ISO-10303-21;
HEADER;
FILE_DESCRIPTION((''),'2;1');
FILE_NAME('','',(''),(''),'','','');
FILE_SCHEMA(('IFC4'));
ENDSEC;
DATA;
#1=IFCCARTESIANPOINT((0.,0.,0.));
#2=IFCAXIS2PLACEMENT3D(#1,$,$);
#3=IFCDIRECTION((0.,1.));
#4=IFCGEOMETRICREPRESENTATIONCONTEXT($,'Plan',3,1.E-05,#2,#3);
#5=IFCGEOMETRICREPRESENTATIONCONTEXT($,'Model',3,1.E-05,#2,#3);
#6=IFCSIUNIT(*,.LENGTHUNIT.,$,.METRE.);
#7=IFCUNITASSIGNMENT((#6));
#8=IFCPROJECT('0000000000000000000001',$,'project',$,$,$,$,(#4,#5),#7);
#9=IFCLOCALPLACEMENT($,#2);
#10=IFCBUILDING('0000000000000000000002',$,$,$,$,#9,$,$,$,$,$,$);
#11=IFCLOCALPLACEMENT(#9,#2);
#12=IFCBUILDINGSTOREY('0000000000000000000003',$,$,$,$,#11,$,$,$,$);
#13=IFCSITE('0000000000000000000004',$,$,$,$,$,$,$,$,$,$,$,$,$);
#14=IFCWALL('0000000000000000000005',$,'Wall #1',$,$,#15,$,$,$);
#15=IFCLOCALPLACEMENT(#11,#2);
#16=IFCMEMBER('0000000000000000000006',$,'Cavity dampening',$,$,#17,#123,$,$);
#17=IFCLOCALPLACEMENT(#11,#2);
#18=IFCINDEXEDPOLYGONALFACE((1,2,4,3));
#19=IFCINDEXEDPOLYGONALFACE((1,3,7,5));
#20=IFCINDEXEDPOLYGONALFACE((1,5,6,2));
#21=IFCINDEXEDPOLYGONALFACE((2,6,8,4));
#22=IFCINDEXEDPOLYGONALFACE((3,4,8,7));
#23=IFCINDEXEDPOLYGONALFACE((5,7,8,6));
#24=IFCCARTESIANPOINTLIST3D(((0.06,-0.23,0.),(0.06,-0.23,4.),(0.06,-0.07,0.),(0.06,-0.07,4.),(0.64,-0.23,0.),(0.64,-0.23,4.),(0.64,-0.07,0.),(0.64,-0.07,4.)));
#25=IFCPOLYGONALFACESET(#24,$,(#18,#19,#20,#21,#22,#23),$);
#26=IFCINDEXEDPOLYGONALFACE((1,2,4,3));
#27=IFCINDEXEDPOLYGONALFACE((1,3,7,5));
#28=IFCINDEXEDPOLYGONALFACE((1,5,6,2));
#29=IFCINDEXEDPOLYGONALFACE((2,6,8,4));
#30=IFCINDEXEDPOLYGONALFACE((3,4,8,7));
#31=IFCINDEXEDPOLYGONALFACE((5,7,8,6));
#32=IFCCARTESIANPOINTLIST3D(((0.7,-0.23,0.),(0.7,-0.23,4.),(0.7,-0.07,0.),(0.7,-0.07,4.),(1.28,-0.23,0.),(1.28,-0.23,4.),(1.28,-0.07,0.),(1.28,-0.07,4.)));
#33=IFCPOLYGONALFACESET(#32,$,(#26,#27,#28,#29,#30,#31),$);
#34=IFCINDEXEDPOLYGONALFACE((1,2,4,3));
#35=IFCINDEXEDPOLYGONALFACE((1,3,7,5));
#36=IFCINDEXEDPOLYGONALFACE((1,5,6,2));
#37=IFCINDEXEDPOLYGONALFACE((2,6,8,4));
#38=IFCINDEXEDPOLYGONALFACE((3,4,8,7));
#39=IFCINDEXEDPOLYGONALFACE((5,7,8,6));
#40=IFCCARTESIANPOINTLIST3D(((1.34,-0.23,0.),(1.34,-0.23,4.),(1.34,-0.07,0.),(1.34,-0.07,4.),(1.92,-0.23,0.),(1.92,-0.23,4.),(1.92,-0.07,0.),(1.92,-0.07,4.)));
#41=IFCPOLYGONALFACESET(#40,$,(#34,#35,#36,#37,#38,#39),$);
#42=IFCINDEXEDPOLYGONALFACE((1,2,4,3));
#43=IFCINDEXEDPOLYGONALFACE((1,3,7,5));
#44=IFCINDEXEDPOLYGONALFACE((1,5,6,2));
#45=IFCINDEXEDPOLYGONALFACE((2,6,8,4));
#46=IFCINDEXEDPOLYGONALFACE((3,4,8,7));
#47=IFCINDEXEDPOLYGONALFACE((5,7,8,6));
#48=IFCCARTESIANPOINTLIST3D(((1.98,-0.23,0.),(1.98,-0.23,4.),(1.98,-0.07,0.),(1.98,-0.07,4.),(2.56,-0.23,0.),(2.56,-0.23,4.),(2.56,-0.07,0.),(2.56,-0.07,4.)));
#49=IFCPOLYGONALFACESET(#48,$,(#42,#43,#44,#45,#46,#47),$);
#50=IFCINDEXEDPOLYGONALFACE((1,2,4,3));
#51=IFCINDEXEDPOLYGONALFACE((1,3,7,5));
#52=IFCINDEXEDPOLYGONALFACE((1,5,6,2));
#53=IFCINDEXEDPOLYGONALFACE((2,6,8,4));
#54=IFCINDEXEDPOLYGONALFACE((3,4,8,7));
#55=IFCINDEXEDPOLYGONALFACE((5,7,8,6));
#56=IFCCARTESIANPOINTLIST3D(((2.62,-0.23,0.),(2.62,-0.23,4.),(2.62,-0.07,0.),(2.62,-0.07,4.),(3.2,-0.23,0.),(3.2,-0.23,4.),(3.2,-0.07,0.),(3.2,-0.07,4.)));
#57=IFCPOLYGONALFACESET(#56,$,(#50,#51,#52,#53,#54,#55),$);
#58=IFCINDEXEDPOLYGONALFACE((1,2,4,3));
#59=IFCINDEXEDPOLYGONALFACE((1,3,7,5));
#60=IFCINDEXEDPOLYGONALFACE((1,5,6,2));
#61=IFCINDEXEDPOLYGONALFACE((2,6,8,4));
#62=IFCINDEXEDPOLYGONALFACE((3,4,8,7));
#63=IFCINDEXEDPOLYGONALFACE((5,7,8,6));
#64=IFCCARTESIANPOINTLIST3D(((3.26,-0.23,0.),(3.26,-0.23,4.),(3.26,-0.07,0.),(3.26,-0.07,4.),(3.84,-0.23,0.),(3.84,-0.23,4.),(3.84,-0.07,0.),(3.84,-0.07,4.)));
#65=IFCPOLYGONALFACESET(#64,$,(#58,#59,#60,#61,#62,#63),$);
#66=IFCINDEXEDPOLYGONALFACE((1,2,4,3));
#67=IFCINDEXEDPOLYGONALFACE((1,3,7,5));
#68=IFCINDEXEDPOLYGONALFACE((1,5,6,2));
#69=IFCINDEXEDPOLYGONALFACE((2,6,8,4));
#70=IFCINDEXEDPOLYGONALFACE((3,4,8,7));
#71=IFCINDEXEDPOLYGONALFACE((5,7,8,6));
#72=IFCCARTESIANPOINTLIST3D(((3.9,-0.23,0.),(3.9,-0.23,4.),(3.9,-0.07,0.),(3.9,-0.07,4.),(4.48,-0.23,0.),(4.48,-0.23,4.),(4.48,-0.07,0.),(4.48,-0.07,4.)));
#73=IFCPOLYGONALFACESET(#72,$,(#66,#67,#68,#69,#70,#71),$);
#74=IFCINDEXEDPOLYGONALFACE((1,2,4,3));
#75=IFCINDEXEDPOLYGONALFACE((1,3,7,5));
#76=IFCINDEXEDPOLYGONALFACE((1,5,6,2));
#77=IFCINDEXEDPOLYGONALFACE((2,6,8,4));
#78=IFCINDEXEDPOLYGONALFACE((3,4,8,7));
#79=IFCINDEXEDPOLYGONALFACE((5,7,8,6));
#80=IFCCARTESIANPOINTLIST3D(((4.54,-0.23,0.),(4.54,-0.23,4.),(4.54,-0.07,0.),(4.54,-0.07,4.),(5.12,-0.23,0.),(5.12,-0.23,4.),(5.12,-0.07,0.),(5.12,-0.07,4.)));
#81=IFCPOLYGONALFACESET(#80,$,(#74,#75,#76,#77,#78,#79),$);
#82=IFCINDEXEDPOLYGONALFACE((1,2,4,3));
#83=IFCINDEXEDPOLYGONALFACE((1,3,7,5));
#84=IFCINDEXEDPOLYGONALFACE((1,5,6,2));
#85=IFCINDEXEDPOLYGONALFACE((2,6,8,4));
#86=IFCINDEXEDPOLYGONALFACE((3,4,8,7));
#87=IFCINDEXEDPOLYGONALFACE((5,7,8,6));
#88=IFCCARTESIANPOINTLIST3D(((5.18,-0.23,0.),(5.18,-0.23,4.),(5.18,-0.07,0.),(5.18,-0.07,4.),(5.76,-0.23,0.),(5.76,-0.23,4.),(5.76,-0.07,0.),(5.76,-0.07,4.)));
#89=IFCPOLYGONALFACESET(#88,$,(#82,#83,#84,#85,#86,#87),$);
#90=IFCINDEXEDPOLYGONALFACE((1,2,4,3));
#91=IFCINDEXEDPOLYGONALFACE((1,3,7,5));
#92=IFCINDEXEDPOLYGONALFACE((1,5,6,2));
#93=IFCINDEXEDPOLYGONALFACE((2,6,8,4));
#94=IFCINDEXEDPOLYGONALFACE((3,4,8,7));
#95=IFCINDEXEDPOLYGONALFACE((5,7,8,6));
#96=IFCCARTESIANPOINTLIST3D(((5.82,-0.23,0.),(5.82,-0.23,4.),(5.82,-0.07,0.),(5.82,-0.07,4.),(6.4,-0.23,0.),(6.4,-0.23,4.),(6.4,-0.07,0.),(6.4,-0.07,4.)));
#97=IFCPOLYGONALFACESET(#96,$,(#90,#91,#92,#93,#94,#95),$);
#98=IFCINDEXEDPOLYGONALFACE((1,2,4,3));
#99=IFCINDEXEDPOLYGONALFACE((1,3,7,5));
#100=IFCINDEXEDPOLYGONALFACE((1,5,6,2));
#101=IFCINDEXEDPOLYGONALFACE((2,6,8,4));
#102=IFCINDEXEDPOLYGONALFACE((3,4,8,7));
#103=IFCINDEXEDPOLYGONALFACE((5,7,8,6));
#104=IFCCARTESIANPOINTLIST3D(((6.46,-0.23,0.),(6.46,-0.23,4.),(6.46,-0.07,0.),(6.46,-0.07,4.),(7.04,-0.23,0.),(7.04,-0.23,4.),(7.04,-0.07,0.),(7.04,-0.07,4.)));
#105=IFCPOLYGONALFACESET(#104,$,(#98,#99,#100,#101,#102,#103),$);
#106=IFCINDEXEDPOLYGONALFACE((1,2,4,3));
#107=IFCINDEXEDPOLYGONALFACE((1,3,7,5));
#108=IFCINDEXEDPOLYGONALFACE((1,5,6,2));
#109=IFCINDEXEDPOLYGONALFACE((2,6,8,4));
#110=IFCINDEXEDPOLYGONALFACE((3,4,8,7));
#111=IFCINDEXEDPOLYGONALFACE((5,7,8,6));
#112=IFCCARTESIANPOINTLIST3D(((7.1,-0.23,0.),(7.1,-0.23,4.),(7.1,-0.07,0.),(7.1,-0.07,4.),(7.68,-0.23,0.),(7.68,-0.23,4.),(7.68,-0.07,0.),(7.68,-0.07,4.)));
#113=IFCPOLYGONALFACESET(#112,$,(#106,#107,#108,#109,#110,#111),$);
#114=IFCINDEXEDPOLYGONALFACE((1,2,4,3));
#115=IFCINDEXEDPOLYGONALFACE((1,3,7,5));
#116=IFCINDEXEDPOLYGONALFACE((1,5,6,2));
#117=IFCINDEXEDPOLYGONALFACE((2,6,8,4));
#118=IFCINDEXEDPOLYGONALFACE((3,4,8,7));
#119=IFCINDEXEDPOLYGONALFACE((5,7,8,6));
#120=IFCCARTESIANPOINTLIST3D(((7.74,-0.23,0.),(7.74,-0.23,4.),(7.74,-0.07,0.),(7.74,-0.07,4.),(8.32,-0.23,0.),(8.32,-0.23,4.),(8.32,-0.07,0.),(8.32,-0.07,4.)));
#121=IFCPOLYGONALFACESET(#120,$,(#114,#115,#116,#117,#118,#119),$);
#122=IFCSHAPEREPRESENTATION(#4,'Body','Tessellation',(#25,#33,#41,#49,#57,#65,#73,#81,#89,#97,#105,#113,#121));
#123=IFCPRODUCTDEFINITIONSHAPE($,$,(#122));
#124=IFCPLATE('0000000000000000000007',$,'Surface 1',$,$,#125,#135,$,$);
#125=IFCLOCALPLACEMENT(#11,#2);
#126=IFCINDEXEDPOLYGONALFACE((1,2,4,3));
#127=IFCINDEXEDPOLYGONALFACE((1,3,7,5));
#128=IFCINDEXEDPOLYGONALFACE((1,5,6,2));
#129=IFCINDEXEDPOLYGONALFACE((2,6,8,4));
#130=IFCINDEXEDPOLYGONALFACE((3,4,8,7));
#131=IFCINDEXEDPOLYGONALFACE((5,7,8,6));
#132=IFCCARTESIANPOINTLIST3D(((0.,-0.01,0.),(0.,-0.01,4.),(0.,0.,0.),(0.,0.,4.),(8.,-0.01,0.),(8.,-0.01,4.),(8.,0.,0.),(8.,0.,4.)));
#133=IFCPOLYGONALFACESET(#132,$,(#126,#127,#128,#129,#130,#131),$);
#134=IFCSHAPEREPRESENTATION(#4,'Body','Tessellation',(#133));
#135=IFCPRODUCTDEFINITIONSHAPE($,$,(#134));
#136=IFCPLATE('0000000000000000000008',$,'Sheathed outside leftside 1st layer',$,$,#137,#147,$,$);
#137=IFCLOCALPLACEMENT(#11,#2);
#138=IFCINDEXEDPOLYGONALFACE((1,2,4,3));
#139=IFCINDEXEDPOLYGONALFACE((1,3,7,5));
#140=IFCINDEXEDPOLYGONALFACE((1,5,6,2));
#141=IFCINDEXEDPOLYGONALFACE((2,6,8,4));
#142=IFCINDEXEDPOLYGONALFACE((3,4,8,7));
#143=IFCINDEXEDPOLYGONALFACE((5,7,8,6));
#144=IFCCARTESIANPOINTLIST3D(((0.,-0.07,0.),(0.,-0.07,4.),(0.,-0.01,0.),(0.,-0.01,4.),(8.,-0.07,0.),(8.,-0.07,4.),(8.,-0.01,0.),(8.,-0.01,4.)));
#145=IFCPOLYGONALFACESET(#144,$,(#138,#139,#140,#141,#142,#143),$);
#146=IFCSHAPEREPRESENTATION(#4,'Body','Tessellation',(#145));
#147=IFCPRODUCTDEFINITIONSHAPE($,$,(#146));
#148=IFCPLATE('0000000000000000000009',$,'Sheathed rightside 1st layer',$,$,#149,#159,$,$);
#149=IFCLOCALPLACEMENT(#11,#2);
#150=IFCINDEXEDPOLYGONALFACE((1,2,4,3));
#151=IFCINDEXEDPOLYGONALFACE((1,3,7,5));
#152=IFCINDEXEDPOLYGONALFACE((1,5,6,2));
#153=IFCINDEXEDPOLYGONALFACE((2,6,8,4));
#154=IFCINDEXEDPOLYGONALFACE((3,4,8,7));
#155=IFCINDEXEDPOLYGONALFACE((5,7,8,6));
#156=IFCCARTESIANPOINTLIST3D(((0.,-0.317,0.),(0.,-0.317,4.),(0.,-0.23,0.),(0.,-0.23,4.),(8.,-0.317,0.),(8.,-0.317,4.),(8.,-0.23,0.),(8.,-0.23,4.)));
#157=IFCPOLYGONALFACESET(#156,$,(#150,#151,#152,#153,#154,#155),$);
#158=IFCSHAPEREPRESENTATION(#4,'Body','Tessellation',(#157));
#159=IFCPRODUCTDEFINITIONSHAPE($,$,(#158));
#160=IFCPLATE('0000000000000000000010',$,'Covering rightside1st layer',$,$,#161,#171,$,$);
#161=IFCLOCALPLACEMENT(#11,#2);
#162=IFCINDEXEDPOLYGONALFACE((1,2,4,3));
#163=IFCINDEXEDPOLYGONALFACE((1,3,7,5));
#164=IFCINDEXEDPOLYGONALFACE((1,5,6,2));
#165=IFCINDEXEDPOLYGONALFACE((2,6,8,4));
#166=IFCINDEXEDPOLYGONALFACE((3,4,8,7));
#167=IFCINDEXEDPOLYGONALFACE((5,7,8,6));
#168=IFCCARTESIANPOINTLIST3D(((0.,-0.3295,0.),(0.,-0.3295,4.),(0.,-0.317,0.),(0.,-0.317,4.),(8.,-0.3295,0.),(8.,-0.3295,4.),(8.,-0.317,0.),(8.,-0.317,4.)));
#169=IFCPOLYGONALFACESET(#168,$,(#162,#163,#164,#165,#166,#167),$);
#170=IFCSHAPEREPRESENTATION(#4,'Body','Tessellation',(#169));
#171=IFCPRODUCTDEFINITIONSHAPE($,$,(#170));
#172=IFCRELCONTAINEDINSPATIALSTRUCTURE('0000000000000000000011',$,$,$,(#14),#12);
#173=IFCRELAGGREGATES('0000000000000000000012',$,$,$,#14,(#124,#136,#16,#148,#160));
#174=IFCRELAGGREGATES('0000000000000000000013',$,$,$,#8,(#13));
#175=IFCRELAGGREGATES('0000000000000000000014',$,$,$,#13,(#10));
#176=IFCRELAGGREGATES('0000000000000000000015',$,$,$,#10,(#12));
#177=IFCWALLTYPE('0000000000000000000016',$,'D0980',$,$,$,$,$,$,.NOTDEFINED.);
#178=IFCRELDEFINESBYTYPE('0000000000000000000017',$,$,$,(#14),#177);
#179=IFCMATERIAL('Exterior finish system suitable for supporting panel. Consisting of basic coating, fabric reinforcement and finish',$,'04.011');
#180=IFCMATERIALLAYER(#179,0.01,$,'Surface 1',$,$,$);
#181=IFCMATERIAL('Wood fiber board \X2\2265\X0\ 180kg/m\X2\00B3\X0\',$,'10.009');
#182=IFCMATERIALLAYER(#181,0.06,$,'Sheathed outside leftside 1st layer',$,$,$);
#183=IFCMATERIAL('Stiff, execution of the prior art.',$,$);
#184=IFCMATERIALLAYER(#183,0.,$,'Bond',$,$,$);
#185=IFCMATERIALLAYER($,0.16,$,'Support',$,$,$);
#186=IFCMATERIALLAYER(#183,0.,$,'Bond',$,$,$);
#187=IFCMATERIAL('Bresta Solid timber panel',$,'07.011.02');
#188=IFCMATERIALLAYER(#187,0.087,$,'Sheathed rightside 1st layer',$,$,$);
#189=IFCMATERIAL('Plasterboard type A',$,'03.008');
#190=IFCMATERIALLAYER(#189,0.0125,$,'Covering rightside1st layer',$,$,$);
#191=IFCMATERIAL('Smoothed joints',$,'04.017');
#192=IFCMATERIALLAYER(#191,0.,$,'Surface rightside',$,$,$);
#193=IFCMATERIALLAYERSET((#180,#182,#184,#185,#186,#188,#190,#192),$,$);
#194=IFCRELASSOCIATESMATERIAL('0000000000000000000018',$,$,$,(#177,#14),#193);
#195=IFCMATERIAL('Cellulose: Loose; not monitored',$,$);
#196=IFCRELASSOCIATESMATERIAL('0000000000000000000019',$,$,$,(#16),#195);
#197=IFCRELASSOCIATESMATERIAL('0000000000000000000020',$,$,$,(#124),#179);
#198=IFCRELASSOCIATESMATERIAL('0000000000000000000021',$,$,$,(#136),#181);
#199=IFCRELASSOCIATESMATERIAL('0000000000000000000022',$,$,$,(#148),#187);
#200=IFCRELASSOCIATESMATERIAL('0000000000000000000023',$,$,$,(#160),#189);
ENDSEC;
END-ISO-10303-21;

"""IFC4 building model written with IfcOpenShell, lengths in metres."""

from ifc_helpers import new_model, si_unit, direction, frame, frame_2d, origin, origin_with_axes, place, context, project, spatial, rectangle, extrude, material, layer, layer_set, type_object, element, aggregate, save


model = new_model("IFC4")

# Units and contexts
plan_context = context("Plan", 3, precision=1e-05, world=origin(), true_north=direction((0.0, 1.0)))
model_context = context("Model", 3, precision=1e-05, world=origin(), true_north=direction((0.0, 1.0)))
ifc_project = project(units=[si_unit("LENGTHUNIT", "METRE")], contexts=[plan_context, model_context])

# Site, building, storey
site = spatial("IfcSite", under=ifc_project)
building_placement = place(None, origin())
building = spatial("IfcBuilding", under=site, at=building_placement)
storey_placement = place(building_placement, origin())
storey = spatial("IfcBuildingStorey", under=building, at=storey_placement)

# Wall, member, plates
ifc_material_1 = material(Name="Exterior finish system suitable for supporting panel. Consisting of basic coating, fabric reinforcement and finish", Category="04.011")
ifc_layer_1 = layer(ifc_material_1, 0.01, Name="Surface 1")
ifc_material_2 = material(Name="Wood fiber board ≥ 180kg/m³", Category="10.009")
ifc_layer_2 = layer(ifc_material_2, 0.06, Name="Sheathed outside leftside 1st layer")
ifc_material_3 = material(Name="Stiff, execution of the prior art.")
ifc_layer_3 = layer(ifc_material_3, 0.0, Name="Bond")
ifc_layer_4 = layer(None, 0.16, Name="Support")
ifc_layer_5 = layer(ifc_material_3, 0.0, Name="Bond")
ifc_material_4 = material(Name="Bresta Solid timber panel", Category="07.011.02")
ifc_layer_6 = layer(ifc_material_4, 0.087, Name="Sheathed rightside 1st layer")
ifc_material_5 = material(Name="Plasterboard type A", Category="03.008")
ifc_layer_7 = layer(ifc_material_5, 0.0125, Name="Covering rightside1st layer")
ifc_material_6 = material(Name="Smoothed joints", Category="04.017")
ifc_layer_8 = layer(ifc_material_6, 0.0, Name="Surface rightside")
ifc_layer_set = layer_set([ifc_layer_1, ifc_layer_2, ifc_layer_3, ifc_layer_4, ifc_layer_5, ifc_layer_6, ifc_layer_7, ifc_layer_8])
wall_type = type_object("IfcWallType", Name="D0980", PredefinedType="NOTDEFINED", material=ifc_layer_set)
wall_placement = place(None, frame((0.0, 0.0, 0.0), z_axis=(0.0, -1.0, 0.0), x_axis=(1.0, 0.0, 0.0)))
wall = element("IfcWall", 1, at=wall_placement, inside=storey, type_object=wall_type, material=ifc_layer_set, Name="Wall #1")
ifc_material_7 = material(Name="Cellulose: Loose; not monitored")
member_1_placement = place(wall_placement, origin())
member_1 = element("IfcMember", 2, at=member_1_placement, material=ifc_material_7, Name="Cavity dampening", context=plan_context, shape_type="SweptSolid", body=[
    extrude(rectangle(XDim=0.58, YDim=0.16, at=frame_2d((0.29, 0.08), x_axis=(1.0, 0.0))), frame((0.06, 4.0, 0.07), z_axis=(0.0, -1.0, 0.0), x_axis=(1.0, 0.0, 0.0)), (0.0, 0.0, 1.0), 4.0),
    extrude(rectangle(XDim=0.58, YDim=0.16, at=frame_2d((0.29, 0.08), x_axis=(1.0, 0.0))), frame((0.7, 4.0, 0.07), z_axis=(0.0, -1.0, 0.0), x_axis=(1.0, 0.0, 0.0)), (0.0, 0.0, 1.0), 4.0),
    extrude(rectangle(XDim=0.58, YDim=0.16, at=frame_2d((0.29, 0.08), x_axis=(1.0, 0.0))), frame((1.34, 4.0, 0.07), z_axis=(0.0, -1.0, 0.0), x_axis=(1.0, 0.0, 0.0)), (0.0, 0.0, 1.0), 4.0),
    extrude(rectangle(XDim=0.58, YDim=0.16, at=frame_2d((0.29, 0.08), x_axis=(1.0, 0.0))), frame((1.98, 4.0, 0.07), z_axis=(0.0, -1.0, 0.0), x_axis=(1.0, 0.0, 0.0)), (0.0, 0.0, 1.0), 4.0),
    extrude(rectangle(XDim=0.58, YDim=0.16, at=frame_2d((0.29, 0.08), x_axis=(1.0, 0.0))), frame((2.62, 4.0, 0.07), z_axis=(0.0, -1.0, 0.0), x_axis=(1.0, 0.0, 0.0)), (0.0, 0.0, 1.0), 4.0),
    extrude(rectangle(XDim=0.58, YDim=0.16, at=frame_2d((0.29, 0.08), x_axis=(1.0, 0.0))), frame((3.26, 4.0, 0.07), z_axis=(0.0, -1.0, 0.0), x_axis=(1.0, 0.0, 0.0)), (0.0, 0.0, 1.0), 4.0),
    extrude(rectangle(XDim=0.58, YDim=0.16, at=frame_2d((0.29, 0.08), x_axis=(1.0, 0.0))), frame((3.9, 4.0, 0.07), z_axis=(0.0, -1.0, 0.0), x_axis=(1.0, 0.0, 0.0)), (0.0, 0.0, 1.0), 4.0),
    extrude(rectangle(XDim=0.58, YDim=0.16, at=frame_2d((0.29, 0.08), x_axis=(1.0, 0.0))), frame((4.54, 4.0, 0.07), z_axis=(0.0, -1.0, 0.0), x_axis=(1.0, 0.0, 0.0)), (0.0, 0.0, 1.0), 4.0),
    extrude(rectangle(XDim=0.58, YDim=0.16, at=frame_2d((0.29, 0.08), x_axis=(1.0, 0.0))), frame((5.18, 4.0, 0.07), z_axis=(0.0, -1.0, 0.0), x_axis=(1.0, 0.0, 0.0)), (0.0, 0.0, 1.0), 4.0),
    extrude(rectangle(XDim=0.58, YDim=0.16, at=frame_2d((0.29, 0.08), x_axis=(1.0, 0.0))), frame((5.82, 4.0, 0.07), z_axis=(0.0, -1.0, 0.0), x_axis=(1.0, 0.0, 0.0)), (0.0, 0.0, 1.0), 4.0),
    extrude(rectangle(XDim=0.58, YDim=0.16, at=frame_2d((0.29, 0.08), x_axis=(1.0, 0.0))), frame((6.46, 4.0, 0.07), z_axis=(0.0, -1.0, 0.0), x_axis=(1.0, 0.0, 0.0)), (0.0, 0.0, 1.0), 4.0),
    extrude(rectangle(XDim=0.58, YDim=0.16, at=frame_2d((0.29, 0.08), x_axis=(1.0, 0.0))), frame((7.1, 4.0, 0.07), z_axis=(0.0, -1.0, 0.0), x_axis=(1.0, 0.0, 0.0)), (0.0, 0.0, 1.0), 4.0),
    extrude(rectangle(XDim=0.58, YDim=0.16, at=frame_2d((0.29, 0.08), x_axis=(1.0, 0.0))), frame((7.74, 4.0, 0.07), z_axis=(0.0, -1.0, 0.0), x_axis=(1.0, 0.0, 0.0)), (0.0, 0.0, 1.0), 4.0),
])
plate_1_placement = place(wall_placement, origin())
plate_1 = element("IfcPlate", 3, at=plate_1_placement, material=ifc_material_1, Name="Surface 1", context=plan_context, shape_type="SweptSolid", body=[
    extrude(rectangle(XDim=8.0, YDim=4.0, at=frame_2d((4.0, 2.0), x_axis=(1.0, 0.0))), origin_with_axes(), (0.0, 0.0, 1.0), 0.01),
])
plate_2_placement = place(wall_placement, origin())
plate_2 = element("IfcPlate", 4, at=plate_2_placement, material=ifc_material_2, Name="Sheathed outside leftside 1st layer", context=plan_context, shape_type="SweptSolid", body=[
    extrude(rectangle(XDim=8.0, YDim=4.0, at=frame_2d((4.0, 2.0), x_axis=(1.0, 0.0))), frame((0.0, 0.0, 0.01), z_axis=(0.0, 0.0, 1.0), x_axis=(1.0, 0.0, 0.0)), (0.0, 0.0, 1.0), 0.06),
])
plate_3_placement = place(wall_placement, origin())
plate_3 = element("IfcPlate", 5, at=plate_3_placement, material=ifc_material_4, Name="Sheathed rightside 1st layer", context=plan_context, shape_type="SweptSolid", body=[
    extrude(rectangle(XDim=8.0, YDim=4.0, at=frame_2d((4.0, 2.0), x_axis=(1.0, 0.0))), frame((0.0, 0.0, 0.23), z_axis=(0.0, 0.0, 1.0), x_axis=(1.0, 0.0, 0.0)), (0.0, 0.0, 1.0), 0.087),
])
plate_4_placement = place(wall_placement, origin())
plate_4 = element("IfcPlate", 6, at=plate_4_placement, material=ifc_material_5, Name="Covering rightside1st layer", context=plan_context, shape_type="SweptSolid", body=[
    extrude(rectangle(XDim=8.0, YDim=4.0, at=frame_2d((4.0, 2.0), x_axis=(1.0, 0.0))), frame((0.0, 0.0, 0.317), z_axis=(0.0, 0.0, 1.0), x_axis=(1.0, 0.0, 0.0)), (0.0, 0.0, 1.0), 0.0125),
])
aggregate(wall, [plate_1, plate_2, member_1, plate_3, plate_4])

save(model, "model.ifc")
